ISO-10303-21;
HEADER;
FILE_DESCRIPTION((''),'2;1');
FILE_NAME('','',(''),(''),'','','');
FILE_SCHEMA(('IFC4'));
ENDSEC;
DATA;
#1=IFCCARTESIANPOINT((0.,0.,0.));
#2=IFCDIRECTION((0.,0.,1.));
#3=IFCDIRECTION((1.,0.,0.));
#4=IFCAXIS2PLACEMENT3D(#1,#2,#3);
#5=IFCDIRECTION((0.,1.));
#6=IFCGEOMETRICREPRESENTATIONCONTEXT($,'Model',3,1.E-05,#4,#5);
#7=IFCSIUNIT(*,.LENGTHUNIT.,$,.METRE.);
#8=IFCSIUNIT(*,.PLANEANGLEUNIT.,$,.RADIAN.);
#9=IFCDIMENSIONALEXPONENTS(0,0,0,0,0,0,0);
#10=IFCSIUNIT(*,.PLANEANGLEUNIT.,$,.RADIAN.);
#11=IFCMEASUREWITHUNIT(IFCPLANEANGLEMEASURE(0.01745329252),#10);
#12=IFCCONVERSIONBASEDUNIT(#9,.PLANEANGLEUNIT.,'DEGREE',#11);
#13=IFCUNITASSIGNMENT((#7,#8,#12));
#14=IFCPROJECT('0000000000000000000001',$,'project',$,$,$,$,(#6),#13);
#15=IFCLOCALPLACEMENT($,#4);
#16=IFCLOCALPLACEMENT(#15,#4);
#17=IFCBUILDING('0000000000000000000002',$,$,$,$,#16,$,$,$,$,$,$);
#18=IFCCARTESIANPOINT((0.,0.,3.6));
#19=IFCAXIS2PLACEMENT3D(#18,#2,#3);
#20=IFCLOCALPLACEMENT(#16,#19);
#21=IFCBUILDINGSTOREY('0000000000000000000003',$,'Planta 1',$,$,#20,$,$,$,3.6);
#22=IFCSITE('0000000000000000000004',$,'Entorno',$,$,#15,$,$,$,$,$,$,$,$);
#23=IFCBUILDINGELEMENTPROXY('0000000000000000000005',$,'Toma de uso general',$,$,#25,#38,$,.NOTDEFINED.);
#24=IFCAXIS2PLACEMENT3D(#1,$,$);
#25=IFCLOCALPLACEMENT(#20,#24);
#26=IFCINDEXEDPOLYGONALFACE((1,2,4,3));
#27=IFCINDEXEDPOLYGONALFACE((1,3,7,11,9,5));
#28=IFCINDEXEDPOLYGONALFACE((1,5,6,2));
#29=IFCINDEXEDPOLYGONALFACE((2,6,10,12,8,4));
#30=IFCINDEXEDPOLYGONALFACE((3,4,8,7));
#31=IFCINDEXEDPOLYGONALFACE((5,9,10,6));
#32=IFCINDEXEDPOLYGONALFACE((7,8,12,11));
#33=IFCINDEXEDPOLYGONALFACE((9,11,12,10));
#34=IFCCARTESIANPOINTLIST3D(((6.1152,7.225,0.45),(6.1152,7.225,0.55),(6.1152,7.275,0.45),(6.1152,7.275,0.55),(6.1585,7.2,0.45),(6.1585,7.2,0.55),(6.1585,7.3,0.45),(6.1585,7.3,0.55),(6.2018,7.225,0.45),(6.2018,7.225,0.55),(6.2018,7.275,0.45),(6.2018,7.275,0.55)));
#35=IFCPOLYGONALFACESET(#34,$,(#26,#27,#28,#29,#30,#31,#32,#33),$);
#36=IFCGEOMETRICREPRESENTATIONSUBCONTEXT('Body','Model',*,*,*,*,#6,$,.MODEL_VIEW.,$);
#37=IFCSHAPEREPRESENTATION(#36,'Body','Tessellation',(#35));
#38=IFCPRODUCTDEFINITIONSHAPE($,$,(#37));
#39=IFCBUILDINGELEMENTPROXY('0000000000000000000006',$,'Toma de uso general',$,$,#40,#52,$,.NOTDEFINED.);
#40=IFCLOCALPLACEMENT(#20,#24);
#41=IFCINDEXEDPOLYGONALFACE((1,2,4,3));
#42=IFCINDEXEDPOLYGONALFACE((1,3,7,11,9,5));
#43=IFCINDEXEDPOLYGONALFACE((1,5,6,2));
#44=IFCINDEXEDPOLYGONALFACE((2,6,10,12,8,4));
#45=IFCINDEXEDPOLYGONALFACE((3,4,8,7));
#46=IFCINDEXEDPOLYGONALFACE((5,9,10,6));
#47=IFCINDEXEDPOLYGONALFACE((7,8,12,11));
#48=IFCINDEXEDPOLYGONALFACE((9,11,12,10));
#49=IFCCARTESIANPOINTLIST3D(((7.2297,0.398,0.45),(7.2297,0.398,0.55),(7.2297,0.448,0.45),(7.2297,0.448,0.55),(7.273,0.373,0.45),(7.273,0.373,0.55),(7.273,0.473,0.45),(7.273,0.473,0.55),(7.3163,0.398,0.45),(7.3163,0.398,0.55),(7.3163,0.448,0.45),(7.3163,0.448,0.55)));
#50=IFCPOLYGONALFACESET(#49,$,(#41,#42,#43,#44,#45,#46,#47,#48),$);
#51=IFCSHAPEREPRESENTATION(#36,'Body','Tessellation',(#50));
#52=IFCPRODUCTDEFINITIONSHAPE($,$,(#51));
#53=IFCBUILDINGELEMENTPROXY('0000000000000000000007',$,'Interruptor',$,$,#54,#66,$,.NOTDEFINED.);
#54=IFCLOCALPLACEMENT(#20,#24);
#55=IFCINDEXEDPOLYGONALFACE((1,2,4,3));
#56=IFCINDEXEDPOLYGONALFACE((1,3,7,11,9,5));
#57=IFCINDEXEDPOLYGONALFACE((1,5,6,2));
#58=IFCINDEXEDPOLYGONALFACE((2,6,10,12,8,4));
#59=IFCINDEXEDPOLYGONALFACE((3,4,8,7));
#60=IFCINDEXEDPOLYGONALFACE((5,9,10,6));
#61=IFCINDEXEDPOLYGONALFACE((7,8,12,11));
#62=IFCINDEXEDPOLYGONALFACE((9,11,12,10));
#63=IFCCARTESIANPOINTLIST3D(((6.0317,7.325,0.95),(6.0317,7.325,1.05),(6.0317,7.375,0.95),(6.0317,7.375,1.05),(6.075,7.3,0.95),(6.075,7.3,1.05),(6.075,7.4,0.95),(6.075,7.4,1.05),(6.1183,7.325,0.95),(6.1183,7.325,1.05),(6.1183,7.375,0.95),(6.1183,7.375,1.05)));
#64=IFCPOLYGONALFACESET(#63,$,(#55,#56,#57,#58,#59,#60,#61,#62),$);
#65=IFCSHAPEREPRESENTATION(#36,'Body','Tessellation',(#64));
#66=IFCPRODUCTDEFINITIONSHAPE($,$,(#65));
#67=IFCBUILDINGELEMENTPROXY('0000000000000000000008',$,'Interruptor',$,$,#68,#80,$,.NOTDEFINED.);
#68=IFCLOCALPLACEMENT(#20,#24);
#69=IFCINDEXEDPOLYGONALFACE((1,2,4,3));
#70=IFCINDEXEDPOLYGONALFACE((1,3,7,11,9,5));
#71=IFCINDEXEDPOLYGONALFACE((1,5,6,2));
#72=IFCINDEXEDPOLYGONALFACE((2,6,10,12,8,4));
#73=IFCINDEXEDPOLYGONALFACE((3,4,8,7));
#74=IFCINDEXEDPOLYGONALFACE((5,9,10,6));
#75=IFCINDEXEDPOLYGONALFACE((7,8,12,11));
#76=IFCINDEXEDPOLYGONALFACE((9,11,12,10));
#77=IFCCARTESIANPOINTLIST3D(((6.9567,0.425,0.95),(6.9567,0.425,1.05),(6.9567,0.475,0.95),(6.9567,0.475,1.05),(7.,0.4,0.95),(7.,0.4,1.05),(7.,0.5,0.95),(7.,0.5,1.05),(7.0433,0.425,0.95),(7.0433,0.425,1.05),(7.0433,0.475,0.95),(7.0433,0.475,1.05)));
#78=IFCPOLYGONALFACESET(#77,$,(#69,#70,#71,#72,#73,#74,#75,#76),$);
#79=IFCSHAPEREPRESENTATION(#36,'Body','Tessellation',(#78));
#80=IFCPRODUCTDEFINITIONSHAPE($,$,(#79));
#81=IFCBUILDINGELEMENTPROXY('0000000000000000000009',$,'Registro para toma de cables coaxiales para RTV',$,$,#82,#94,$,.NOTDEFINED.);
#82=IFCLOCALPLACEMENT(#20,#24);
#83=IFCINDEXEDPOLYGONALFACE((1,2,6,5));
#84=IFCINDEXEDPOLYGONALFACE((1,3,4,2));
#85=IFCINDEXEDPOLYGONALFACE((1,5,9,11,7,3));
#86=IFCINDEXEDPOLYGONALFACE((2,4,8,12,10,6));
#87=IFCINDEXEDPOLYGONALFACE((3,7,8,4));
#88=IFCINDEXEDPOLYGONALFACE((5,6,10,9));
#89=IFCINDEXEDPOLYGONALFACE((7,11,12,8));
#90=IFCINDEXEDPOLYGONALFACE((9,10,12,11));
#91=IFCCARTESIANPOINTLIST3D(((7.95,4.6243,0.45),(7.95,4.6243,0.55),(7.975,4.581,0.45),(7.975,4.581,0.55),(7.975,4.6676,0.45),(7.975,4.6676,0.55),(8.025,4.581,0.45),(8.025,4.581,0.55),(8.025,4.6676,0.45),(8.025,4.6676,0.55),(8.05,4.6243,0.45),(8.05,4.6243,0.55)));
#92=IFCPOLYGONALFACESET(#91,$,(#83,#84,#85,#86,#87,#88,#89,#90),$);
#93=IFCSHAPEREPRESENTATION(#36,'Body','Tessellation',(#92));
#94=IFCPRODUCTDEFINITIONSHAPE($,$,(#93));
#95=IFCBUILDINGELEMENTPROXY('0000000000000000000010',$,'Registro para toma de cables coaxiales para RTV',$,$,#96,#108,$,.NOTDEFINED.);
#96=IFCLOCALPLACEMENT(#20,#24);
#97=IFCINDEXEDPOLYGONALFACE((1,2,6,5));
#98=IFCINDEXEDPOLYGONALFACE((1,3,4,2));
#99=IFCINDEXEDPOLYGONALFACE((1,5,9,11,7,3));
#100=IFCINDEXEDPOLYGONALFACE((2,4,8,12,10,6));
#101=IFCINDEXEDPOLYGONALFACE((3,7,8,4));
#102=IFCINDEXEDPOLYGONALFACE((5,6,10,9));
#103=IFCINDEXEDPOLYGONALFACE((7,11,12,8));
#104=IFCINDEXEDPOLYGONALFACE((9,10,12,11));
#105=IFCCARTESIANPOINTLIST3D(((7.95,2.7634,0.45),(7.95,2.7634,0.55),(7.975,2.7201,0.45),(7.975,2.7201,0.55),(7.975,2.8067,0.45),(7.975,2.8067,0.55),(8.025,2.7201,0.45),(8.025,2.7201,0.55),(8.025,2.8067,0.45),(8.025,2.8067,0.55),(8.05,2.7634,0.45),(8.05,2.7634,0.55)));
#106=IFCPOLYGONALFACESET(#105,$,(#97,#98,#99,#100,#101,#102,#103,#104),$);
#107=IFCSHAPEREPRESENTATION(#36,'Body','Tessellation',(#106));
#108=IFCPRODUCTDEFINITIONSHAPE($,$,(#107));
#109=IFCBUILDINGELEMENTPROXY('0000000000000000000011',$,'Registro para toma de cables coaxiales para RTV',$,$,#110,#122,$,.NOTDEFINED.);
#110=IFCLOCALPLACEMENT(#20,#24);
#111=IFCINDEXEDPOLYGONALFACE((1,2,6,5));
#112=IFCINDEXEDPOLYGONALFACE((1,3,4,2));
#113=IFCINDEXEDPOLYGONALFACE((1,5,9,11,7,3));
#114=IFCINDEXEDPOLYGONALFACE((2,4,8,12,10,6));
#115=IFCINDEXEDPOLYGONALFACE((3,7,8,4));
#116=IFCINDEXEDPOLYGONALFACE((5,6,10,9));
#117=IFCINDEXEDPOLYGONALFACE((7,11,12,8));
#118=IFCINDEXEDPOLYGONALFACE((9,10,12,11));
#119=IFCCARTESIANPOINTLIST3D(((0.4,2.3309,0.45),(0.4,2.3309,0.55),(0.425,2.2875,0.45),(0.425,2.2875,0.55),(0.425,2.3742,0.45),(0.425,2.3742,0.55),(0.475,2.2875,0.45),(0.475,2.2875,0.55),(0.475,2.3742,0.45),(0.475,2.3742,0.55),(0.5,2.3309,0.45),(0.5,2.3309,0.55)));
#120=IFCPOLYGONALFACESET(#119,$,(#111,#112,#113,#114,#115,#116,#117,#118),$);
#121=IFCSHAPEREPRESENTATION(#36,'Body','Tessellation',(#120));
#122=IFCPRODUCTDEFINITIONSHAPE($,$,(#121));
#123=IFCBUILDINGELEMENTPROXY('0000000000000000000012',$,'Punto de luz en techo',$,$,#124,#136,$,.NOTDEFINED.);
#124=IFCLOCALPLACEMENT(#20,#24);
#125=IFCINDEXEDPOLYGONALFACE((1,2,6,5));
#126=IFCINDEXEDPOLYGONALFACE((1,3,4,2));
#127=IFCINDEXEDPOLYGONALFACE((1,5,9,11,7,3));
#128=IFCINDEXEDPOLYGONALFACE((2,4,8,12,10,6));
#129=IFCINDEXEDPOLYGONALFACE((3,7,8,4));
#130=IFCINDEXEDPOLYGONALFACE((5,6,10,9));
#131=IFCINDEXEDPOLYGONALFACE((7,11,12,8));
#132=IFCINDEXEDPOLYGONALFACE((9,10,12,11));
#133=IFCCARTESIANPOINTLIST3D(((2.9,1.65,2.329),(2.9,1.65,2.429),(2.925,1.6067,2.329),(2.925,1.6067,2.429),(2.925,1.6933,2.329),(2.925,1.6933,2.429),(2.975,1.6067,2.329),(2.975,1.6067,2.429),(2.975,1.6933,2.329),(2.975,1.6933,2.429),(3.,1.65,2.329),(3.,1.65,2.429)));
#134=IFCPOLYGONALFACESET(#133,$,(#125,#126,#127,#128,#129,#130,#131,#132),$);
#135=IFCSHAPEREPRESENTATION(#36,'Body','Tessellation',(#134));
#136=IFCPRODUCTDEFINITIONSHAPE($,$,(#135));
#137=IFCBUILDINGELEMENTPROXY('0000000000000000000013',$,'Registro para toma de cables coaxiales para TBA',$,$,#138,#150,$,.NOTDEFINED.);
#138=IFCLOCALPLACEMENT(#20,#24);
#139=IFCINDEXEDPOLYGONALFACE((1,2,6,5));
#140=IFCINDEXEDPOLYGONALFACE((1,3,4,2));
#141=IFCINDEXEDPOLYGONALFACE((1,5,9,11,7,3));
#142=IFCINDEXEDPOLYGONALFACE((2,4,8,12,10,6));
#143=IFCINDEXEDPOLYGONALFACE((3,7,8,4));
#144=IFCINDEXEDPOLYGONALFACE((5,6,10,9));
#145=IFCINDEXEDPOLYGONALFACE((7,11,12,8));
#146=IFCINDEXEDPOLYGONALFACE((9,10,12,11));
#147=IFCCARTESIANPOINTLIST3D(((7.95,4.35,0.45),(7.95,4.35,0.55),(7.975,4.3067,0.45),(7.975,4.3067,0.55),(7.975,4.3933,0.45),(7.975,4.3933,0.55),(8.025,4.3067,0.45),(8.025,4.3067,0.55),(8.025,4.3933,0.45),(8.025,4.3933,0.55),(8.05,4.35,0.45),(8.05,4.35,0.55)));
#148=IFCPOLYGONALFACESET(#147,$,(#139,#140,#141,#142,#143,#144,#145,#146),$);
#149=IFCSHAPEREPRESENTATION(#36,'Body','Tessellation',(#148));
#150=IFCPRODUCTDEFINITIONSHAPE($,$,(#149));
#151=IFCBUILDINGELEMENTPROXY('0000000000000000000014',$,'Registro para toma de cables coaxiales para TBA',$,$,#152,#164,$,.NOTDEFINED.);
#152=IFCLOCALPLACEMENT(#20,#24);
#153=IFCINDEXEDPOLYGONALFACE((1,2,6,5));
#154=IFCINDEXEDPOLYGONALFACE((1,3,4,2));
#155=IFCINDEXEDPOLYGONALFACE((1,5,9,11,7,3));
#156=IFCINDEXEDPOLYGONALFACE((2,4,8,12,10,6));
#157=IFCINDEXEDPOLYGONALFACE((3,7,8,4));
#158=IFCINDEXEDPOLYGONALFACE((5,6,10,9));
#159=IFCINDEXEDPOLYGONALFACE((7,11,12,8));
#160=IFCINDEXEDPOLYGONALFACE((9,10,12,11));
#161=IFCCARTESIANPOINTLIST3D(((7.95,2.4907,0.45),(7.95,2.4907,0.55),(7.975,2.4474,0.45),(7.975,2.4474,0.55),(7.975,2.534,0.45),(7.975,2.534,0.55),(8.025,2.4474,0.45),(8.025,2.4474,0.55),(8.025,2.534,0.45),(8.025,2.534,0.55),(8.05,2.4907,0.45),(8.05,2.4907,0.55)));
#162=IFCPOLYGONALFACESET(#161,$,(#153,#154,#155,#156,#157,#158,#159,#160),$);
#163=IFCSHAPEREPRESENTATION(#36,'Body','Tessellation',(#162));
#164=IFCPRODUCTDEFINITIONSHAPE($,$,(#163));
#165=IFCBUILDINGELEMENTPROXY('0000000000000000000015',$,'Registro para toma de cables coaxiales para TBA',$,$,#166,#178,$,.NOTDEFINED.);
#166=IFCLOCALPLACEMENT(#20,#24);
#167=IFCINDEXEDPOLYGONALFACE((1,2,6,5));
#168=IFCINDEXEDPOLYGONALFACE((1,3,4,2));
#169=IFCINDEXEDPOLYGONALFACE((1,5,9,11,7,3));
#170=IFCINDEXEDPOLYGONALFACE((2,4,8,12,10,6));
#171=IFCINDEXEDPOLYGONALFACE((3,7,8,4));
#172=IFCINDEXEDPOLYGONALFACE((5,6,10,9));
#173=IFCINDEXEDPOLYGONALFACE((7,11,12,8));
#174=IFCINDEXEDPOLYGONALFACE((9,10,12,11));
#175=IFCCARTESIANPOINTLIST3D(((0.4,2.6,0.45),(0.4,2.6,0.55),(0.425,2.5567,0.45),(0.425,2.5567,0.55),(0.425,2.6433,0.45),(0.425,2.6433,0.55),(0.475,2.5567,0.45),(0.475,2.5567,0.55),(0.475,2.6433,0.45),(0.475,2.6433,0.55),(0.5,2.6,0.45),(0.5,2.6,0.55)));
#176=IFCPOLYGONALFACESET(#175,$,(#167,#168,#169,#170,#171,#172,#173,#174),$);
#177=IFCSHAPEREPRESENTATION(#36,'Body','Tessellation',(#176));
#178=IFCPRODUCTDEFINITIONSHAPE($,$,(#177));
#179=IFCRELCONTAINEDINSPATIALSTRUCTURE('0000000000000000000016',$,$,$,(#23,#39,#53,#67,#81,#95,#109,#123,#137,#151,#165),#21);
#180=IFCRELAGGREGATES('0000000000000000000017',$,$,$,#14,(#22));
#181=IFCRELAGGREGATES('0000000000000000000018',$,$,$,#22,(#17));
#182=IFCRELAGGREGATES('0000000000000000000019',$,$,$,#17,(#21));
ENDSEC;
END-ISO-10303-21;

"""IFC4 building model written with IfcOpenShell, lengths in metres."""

from ifc_helpers import new_model, entity, si_unit, converted_unit, direction, frame, origin_with_axes, place, context, subcontext, project, spatial, polyline, outline, extrude, source, transform, mapped, element, save


model = new_model("IFC4")

# Units and contexts
model_context = context("Model", 3, precision=1e-05, world=origin_with_axes(), true_north=direction((0.0, 1.0)))
body_context = subcontext(model_context, "Body", "Model", "MODEL_VIEW")
ifc_project = project(units=[si_unit("LENGTHUNIT", "METRE"), si_unit("PLANEANGLEUNIT", "RADIAN"), converted_unit("PLANEANGLEUNIT", "DEGREE", entity("IfcPlaneAngleMeasure", 0.01745329252), si_unit("PLANEANGLEUNIT", "RADIAN"), dimensions=[0, 0, 0, 0, 0, 0, 0])], contexts=[model_context])

# Site, building, storey
site_placement = place(None, origin_with_axes())
site = spatial("IfcSite", under=ifc_project, at=site_placement, Name="Entorno")
building_placement = place(site_placement, origin_with_axes())
building = spatial("IfcBuilding", under=site, at=building_placement)
storey_placement = place(building_placement, frame((0.0, 0.0, 3.6), z_axis=(0.0, 0.0, 1.0), x_axis=(1.0, 0.0, 0.0)))
storey = spatial("IfcBuildingStorey", under=building, at=storey_placement, Name="Planta 1", Elevation=3.6)

# Building element proxies
shared_shape_1 = source(origin_with_axes(), body_context, "Body", "SolidModel", [
    extrude(outline(polyline([(0.05, 0.0), (0.025, 0.0433), (-0.025, 0.0433), (-0.05, 0.0), (-0.025, -0.0433), (0.025, -0.0433), (0.05, 0.0)])), frame((0.0, 0.0, -0.05), z_axis=(0.0, 0.0, 1.0), x_axis=(1.0, 0.0, 0.0)), (0.0, 0.0, 1.0), 0.1),
])
proxy_1_placement = place(storey_placement, frame((0.0, 0.0, -3.6), z_axis=(0.0, 0.0, 1.0), x_axis=(1.0, 0.0, 0.0)))
element("IfcBuildingElementProxy", 1, at=proxy_1_placement, inside=storey, Name="Toma de uso general", PredefinedType="NOTDEFINED", context=body_context, shape_type="Brep", body=[
    mapped(shared_shape_1, transform((6.1585, 7.25, 4.1), x_axis=(0.0, 1.0, 0.0), y_axis=(-1.0, 0.0, 0.0), z_axis=(0.0, 0.0, 1.0))),
])
proxy_2_placement = place(storey_placement, frame((0.0, 0.0, -3.6), z_axis=(0.0, 0.0, 1.0), x_axis=(1.0, 0.0, 0.0)))
element("IfcBuildingElementProxy", 2, at=proxy_2_placement, inside=storey, Name="Toma de uso general", PredefinedType="NOTDEFINED", context=body_context, shape_type="Brep", body=[
    mapped(shared_shape_1, transform((7.273, 0.423, 4.1), x_axis=(0.0, 1.0, 0.0), y_axis=(-1.0, 0.0, 0.0), z_axis=(0.0, 0.0, 1.0))),
])
shared_shape_2 = source(origin_with_axes(), body_context, "Body", "SolidModel", [
    extrude(outline(polyline([(0.05, 0.0), (0.025, 0.0433), (-0.025, 0.0433), (-0.05, 0.0), (-0.025, -0.0433), (0.025, -0.0433), (0.05, 0.0)])), frame((0.0, 0.0, -0.05), z_axis=(0.0, 0.0, 1.0), x_axis=(1.0, 0.0, 0.0)), (0.0, 0.0, 1.0), 0.1),
])
proxy_3_placement = place(storey_placement, frame((0.0, 0.0, -3.6), z_axis=(0.0, 0.0, 1.0), x_axis=(1.0, 0.0, 0.0)))
element("IfcBuildingElementProxy", 3, at=proxy_3_placement, inside=storey, Name="Interruptor", PredefinedType="NOTDEFINED", context=body_context, shape_type="Brep", body=[
    mapped(shared_shape_2, transform((6.075, 7.35, 4.6), x_axis=(0.0, 1.0, 0.0), y_axis=(-1.0, 0.0, 0.0), z_axis=(0.0, 0.0, 1.0))),
])
proxy_4_placement = place(storey_placement, frame((0.0, 0.0, -3.6), z_axis=(0.0, 0.0, 1.0), x_axis=(1.0, 0.0, 0.0)))
element("IfcBuildingElementProxy", 4, at=proxy_4_placement, inside=storey, Name="Interruptor", PredefinedType="NOTDEFINED", context=body_context, shape_type="Brep", body=[
    mapped(shared_shape_2, transform((7.0, 0.45, 4.6), x_axis=(0.0, 1.0, 0.0), y_axis=(-1.0, 0.0, 0.0), z_axis=(0.0, 0.0, 1.0))),
])
shared_shape_3 = source(origin_with_axes(), body_context, "Body", "SolidModel", [
    extrude(outline(polyline([(0.05, 0.0), (0.025, 0.0433), (-0.025, 0.0433), (-0.05, 0.0), (-0.025, -0.0433), (0.025, -0.0433), (0.05, 0.0)])), frame((0.0, 0.0, -0.05), z_axis=(0.0, 0.0, 1.0), x_axis=(1.0, 0.0, 0.0)), (0.0, 0.0, 1.0), 0.1),
])
proxy_5_placement = place(storey_placement, frame((0.0, 0.0, -3.6), z_axis=(0.0, 0.0, 1.0), x_axis=(1.0, 0.0, 0.0)))
element("IfcBuildingElementProxy", 5, at=proxy_5_placement, inside=storey, Name="Registro para toma de cables coaxiales para RTV", PredefinedType="NOTDEFINED", context=body_context, shape_type="Brep", body=[
    mapped(shared_shape_3, transform((8.0, 4.6243, 4.1), x_axis=(1.0, 0.0, 0.0), y_axis=(0.0, 1.0, 0.0), z_axis=(0.0, 0.0, 1.0))),
])
proxy_6_placement = place(storey_placement, frame((0.0, 0.0, -3.6), z_axis=(0.0, 0.0, 1.0), x_axis=(1.0, 0.0, 0.0)))
element("IfcBuildingElementProxy", 6, at=proxy_6_placement, inside=storey, Name="Registro para toma de cables coaxiales para RTV", PredefinedType="NOTDEFINED", context=body_context, shape_type="Brep", body=[
    mapped(shared_shape_3, transform((8.0, 2.7634, 4.1), x_axis=(1.0, 0.0, 0.0), y_axis=(0.0, 1.0, 0.0), z_axis=(0.0, 0.0, 1.0))),
])
proxy_7_placement = place(storey_placement, frame((0.0, 0.0, -3.6), z_axis=(0.0, 0.0, 1.0), x_axis=(1.0, 0.0, 0.0)))
element("IfcBuildingElementProxy", 7, at=proxy_7_placement, inside=storey, Name="Registro para toma de cables coaxiales para RTV", PredefinedType="NOTDEFINED", context=body_context, shape_type="Brep", body=[
    mapped(shared_shape_3, transform((0.45, 2.3309, 4.1), x_axis=(1.0, 0.0, 0.0), y_axis=(0.0, 1.0, 0.0), z_axis=(0.0, 0.0, 1.0))),
])
shared_shape_4 = source(origin_with_axes(), body_context, "Body", "SolidModel", [
    extrude(outline(polyline([(0.05, 0.0), (0.025, 0.0433), (-0.025, 0.0433), (-0.05, 0.0), (-0.025, -0.0433), (0.025, -0.0433), (0.05, 0.0)])), frame((0.0, 0.0, -0.05), z_axis=(0.0, 0.0, 1.0), x_axis=(1.0, 0.0, 0.0)), (0.0, 0.0, 1.0), 0.1),
])
proxy_8_placement = place(storey_placement, frame((0.0, 0.0, -3.6), z_axis=(0.0, 0.0, 1.0), x_axis=(1.0, 0.0, 0.0)))
element("IfcBuildingElementProxy", 8, at=proxy_8_placement, inside=storey, Name="Punto de luz en techo", PredefinedType="NOTDEFINED", context=body_context, shape_type="Brep", body=[
    mapped(shared_shape_4, transform((2.95, 1.65, 5.979), x_axis=(1.0, 0.0, 0.0), y_axis=(0.0, 1.0, 0.0), z_axis=(0.0, 0.0, 1.0))),
])
shared_shape_5 = source(origin_with_axes(), body_context, "Body", "SolidModel", [
    extrude(outline(polyline([(0.05, 0.0), (0.025, 0.0433), (-0.025, 0.0433), (-0.05, 0.0), (-0.025, -0.0433), (0.025, -0.0433), (0.05, 0.0)])), frame((0.0, 0.0, -0.05), z_axis=(0.0, 0.0, 1.0), x_axis=(1.0, 0.0, 0.0)), (0.0, 0.0, 1.0), 0.1),
])
proxy_9_placement = place(storey_placement, frame((0.0, 0.0, -3.6), z_axis=(0.0, 0.0, 1.0), x_axis=(1.0, 0.0, 0.0)))
element("IfcBuildingElementProxy", 9, at=proxy_9_placement, inside=storey, Name="Registro para toma de cables coaxiales para TBA", PredefinedType="NOTDEFINED", context=body_context, shape_type="Brep", body=[
    mapped(shared_shape_5, transform((8.0, 4.35, 4.1), x_axis=(1.0, 0.0, 0.0), y_axis=(0.0, 1.0, 0.0), z_axis=(0.0, 0.0, 1.0))),
])
proxy_10_placement = place(storey_placement, frame((0.0, 0.0, -3.6), z_axis=(0.0, 0.0, 1.0), x_axis=(1.0, 0.0, 0.0)))
element("IfcBuildingElementProxy", 10, at=proxy_10_placement, inside=storey, Name="Registro para toma de cables coaxiales para TBA", PredefinedType="NOTDEFINED", context=body_context, shape_type="Brep", body=[
    mapped(shared_shape_5, transform((8.0, 2.4907, 4.1), x_axis=(1.0, 0.0, 0.0), y_axis=(0.0, 1.0, 0.0), z_axis=(0.0, 0.0, 1.0))),
])
proxy_11_placement = place(storey_placement, frame((0.0, 0.0, -3.6), z_axis=(0.0, 0.0, 1.0), x_axis=(1.0, 0.0, 0.0)))
element("IfcBuildingElementProxy", 11, at=proxy_11_placement, inside=storey, Name="Registro para toma de cables coaxiales para TBA", PredefinedType="NOTDEFINED", context=body_context, shape_type="Brep", body=[
    mapped(shared_shape_5, transform((0.45, 2.6, 4.1), x_axis=(1.0, 0.0, 0.0), y_axis=(0.0, 1.0, 0.0), z_axis=(0.0, 0.0, 1.0))),
])

save(model, "model.ifc")
